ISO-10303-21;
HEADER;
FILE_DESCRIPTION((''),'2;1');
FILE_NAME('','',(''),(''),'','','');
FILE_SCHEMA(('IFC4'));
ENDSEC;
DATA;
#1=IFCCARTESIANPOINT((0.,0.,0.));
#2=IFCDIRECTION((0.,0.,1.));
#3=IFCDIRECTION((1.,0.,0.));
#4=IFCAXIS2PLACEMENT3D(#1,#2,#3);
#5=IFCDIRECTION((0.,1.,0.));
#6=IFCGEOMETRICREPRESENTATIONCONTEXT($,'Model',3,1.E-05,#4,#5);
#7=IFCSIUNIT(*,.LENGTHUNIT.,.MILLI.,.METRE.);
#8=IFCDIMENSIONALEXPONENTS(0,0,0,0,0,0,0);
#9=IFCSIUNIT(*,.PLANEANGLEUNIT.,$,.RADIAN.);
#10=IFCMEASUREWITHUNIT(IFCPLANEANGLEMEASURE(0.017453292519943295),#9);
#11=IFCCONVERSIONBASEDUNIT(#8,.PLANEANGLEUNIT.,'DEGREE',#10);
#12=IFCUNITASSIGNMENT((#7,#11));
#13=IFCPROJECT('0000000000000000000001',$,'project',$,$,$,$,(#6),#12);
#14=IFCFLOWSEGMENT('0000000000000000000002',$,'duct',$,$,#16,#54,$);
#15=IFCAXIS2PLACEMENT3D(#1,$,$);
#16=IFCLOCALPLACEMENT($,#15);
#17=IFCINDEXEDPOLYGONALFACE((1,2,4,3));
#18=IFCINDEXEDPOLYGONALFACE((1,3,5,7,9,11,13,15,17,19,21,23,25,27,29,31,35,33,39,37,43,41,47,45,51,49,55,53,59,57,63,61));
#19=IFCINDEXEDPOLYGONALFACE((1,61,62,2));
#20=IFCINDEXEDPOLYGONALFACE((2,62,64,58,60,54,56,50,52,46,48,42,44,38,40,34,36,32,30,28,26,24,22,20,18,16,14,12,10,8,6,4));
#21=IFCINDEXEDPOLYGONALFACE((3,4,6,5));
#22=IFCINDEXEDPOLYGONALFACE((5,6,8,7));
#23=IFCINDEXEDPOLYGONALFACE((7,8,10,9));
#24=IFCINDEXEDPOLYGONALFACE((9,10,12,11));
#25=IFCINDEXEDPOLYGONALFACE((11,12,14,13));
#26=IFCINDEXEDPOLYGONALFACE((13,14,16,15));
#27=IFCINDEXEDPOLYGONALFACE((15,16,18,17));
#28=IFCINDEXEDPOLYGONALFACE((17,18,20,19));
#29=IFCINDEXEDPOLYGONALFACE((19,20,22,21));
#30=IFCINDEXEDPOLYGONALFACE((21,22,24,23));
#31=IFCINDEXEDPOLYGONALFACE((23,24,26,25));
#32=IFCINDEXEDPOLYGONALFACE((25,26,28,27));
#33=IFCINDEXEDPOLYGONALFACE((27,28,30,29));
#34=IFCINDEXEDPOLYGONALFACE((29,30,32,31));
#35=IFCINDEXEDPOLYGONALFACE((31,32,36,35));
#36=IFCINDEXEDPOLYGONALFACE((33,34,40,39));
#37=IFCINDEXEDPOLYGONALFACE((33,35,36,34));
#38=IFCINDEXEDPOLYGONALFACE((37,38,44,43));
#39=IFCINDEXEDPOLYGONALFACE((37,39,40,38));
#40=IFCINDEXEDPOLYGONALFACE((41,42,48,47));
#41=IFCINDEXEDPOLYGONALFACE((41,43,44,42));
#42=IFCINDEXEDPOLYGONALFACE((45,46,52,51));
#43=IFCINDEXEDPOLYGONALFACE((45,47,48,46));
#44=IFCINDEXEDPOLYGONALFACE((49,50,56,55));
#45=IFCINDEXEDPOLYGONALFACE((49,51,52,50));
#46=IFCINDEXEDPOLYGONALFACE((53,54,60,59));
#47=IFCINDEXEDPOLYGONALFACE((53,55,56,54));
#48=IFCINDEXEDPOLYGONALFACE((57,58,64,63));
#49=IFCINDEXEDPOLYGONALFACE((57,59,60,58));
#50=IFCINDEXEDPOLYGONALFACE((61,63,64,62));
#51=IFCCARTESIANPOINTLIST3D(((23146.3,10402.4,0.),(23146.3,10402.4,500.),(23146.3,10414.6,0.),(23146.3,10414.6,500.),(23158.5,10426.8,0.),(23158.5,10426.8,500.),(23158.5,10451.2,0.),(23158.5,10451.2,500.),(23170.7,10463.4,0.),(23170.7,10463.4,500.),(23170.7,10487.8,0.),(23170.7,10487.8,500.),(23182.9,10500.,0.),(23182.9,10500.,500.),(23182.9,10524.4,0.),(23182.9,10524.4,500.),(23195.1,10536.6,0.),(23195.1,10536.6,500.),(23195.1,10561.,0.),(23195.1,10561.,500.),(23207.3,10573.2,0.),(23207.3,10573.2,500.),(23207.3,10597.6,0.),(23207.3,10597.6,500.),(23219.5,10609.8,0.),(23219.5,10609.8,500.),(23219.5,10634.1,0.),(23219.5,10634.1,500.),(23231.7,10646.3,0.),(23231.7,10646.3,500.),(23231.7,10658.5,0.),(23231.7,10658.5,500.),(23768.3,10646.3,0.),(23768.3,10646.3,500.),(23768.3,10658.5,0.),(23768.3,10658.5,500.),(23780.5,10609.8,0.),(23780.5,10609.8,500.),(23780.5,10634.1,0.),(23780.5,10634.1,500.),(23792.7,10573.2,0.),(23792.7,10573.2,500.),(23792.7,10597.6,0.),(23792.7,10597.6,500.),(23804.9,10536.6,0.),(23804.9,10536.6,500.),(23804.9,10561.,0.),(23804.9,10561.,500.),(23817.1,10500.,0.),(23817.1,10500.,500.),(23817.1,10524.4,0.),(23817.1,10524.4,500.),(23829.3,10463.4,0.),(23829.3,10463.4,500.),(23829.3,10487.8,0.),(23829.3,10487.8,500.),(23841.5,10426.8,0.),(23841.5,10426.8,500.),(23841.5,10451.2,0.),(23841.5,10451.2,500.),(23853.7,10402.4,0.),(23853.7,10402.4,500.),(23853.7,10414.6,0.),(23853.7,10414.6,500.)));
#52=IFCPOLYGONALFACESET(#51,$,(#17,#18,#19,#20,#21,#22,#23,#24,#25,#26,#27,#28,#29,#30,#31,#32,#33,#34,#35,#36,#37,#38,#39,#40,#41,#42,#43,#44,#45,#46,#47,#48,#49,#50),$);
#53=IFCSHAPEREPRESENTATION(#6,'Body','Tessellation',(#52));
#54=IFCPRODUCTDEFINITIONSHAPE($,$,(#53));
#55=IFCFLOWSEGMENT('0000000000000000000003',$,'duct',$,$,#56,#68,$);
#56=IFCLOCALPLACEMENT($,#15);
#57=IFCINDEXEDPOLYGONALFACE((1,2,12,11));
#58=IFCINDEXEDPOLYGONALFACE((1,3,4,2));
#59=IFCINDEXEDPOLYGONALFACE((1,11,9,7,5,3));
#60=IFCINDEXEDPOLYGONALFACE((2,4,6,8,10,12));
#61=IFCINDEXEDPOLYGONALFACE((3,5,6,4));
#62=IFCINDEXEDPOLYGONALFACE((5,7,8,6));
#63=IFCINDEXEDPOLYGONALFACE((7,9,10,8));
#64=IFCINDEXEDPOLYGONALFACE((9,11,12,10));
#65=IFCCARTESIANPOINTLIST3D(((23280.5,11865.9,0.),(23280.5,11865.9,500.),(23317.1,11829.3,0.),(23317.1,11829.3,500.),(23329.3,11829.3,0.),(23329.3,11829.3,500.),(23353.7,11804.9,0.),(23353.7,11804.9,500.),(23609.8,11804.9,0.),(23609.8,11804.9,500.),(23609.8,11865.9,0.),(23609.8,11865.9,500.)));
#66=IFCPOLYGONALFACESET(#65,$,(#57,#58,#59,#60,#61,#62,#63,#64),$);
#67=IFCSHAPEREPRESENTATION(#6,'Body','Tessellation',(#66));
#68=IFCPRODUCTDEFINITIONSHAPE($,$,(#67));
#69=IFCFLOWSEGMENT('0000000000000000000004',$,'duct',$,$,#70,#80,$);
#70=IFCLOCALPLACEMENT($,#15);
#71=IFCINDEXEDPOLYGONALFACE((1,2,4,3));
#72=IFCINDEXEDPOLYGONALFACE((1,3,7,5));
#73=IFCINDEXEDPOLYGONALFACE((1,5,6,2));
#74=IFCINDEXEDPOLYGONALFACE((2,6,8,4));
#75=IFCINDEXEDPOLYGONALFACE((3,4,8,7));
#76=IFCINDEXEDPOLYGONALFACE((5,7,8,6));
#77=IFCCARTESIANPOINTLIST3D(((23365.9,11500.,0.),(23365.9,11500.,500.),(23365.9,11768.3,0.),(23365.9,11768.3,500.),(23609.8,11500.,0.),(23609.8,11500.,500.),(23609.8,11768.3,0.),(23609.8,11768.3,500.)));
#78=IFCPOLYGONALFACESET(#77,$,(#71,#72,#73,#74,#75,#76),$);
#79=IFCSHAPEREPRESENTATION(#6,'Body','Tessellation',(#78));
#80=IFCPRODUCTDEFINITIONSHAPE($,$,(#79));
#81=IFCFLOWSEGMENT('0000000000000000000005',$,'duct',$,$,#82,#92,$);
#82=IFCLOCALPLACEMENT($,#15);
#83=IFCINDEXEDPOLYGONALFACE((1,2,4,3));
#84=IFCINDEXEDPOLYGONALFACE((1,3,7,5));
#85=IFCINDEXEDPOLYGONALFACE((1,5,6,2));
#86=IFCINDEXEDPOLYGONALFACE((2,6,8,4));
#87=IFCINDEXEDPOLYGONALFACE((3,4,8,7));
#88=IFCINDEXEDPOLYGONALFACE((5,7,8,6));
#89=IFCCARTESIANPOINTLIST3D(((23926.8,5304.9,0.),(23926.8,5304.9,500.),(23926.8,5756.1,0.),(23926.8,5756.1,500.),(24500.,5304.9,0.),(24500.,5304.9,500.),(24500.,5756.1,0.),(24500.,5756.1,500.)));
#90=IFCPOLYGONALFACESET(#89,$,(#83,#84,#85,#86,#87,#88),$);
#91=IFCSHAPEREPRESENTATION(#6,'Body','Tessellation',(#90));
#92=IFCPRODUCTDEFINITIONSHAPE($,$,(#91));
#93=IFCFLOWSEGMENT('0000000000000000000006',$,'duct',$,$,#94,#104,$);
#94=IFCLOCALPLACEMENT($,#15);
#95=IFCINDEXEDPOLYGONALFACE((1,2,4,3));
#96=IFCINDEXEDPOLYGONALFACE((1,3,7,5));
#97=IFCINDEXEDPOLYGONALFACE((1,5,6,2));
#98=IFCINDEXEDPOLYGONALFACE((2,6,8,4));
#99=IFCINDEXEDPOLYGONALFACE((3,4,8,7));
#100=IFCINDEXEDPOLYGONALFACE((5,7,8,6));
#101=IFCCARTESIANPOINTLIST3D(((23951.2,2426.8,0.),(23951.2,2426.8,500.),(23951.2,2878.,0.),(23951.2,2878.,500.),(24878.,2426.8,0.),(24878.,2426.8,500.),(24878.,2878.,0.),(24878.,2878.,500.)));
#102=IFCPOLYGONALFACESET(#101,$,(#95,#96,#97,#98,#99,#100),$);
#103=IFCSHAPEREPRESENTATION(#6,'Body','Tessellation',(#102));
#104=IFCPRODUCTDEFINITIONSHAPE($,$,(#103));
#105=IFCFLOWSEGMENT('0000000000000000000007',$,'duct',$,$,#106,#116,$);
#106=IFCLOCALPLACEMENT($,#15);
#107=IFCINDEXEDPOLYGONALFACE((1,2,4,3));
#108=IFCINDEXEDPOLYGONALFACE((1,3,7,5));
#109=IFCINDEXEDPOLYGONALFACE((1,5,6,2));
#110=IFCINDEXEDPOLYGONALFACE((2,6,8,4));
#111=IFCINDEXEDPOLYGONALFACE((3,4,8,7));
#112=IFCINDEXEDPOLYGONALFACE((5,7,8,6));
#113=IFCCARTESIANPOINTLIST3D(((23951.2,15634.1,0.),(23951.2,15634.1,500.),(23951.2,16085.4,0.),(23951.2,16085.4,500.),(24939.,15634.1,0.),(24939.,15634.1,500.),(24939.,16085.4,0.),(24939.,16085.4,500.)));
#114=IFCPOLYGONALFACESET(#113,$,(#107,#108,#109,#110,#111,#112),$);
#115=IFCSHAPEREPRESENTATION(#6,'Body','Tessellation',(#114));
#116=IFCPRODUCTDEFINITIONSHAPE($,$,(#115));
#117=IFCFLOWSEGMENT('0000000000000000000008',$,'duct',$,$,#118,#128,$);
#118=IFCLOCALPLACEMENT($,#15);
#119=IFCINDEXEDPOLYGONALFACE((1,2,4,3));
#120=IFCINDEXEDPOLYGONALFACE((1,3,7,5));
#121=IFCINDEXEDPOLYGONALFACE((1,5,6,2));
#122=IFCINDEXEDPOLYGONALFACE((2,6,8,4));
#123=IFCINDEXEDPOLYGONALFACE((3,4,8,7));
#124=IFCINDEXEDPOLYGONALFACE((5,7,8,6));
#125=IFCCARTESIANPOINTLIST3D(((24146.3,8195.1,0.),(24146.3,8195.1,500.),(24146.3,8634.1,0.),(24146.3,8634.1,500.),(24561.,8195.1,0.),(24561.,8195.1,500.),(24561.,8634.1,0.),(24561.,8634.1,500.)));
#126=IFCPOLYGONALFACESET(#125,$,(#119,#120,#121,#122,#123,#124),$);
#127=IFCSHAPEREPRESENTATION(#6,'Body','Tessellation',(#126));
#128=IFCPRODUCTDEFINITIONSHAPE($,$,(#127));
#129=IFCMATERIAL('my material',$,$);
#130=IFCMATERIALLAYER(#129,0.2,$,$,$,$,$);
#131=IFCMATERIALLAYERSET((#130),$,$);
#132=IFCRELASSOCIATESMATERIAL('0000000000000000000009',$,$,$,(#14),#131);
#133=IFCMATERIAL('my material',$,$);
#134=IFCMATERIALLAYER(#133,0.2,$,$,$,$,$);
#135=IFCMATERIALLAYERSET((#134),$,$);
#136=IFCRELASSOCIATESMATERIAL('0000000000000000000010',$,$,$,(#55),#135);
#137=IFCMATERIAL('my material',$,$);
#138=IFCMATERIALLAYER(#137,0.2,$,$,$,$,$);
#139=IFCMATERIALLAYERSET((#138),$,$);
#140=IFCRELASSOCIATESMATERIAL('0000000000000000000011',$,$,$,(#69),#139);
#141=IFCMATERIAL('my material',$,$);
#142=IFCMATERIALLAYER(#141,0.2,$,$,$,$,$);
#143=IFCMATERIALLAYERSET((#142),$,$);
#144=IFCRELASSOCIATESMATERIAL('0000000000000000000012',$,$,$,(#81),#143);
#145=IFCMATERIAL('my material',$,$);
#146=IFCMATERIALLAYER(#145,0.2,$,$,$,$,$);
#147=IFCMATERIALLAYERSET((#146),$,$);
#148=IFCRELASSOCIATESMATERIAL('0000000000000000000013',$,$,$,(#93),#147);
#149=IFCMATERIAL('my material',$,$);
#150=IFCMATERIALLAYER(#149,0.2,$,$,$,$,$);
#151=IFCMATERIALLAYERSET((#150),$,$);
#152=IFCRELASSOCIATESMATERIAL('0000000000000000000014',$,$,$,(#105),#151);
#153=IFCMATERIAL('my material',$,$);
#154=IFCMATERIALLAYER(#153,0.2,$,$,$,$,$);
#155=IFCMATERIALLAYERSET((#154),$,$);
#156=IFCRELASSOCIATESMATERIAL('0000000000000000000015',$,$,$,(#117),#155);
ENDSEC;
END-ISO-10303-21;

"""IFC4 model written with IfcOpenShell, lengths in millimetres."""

from ifc_helpers import new_model, entity, si_unit, converted_unit, direction, origin_with_axes, place, context, project, polyline, outline, extrude, material, layer, layer_set, layer_usage, element, save


model = new_model("IFC4")

# Units and contexts
model_context = context("Model", 3, precision=1e-05, world=origin_with_axes(), true_north=direction((0.0, 1.0, 0.0)))
ifc_project = project(units=[si_unit("LENGTHUNIT", "METRE", prefix="MILLI"), converted_unit("PLANEANGLEUNIT", "DEGREE", entity("IfcPlaneAngleMeasure", 0.017453292519943295), si_unit("PLANEANGLEUNIT", "RADIAN"), dimensions=[0, 0, 0, 0, 0, 0, 0])], contexts=[model_context])

# Flow segments
ifc_material_1 = material(Name="my material")
ifc_layer_1 = layer(ifc_material_1, 0.2)
ifc_layer_set_1 = layer_set([ifc_layer_1])
ifc_layer_usage_1 = layer_usage(ifc_layer_set_1, "AXIS2", "POSITIVE", -0.1)
flow_segment_1_placement = place(None, origin_with_axes())
element("IfcFlowSegment", 1, at=flow_segment_1_placement, material=ifc_layer_usage_1, Name="duct", context=model_context, shape_type="SweptSolid", body=[
    extrude(outline(polyline([(23146.3, 10402.4), (23853.7, 10402.4), (23853.7, 10414.6), (23841.5, 10426.8), (23841.5, 10451.2), (23829.3, 10463.4), (23829.3, 10487.8), (23817.1, 10500.0), (23817.1, 10524.4), (23804.9, 10536.6), (23804.9, 10561.0), (23792.7, 10573.2), (23792.7, 10597.6), (23780.5, 10609.8), (23780.5, 10634.1), (23768.3, 10646.3), (23768.3, 10658.5), (23231.7, 10658.5), (23231.7, 10646.3), (23219.5, 10634.1), (23219.5, 10609.8), (23207.3, 10597.6), (23207.3, 10573.2), (23195.1, 10561.0), (23195.1, 10536.6), (23182.9, 10524.4), (23182.9, 10500.0), (23170.7, 10487.8), (23170.7, 10463.4), (23158.5, 10451.2), (23158.5, 10426.8), (23146.3, 10414.6), (23146.3, 10402.4)])), origin_with_axes(), (0.0, 0.0, 1.0), 500.0),
])
ifc_material_2 = material(Name="my material")
ifc_layer_2 = layer(ifc_material_2, 0.2)
ifc_layer_set_2 = layer_set([ifc_layer_2])
ifc_layer_usage_2 = layer_usage(ifc_layer_set_2, "AXIS2", "POSITIVE", -0.1)
flow_segment_2_placement = place(None, origin_with_axes())
element("IfcFlowSegment", 2, at=flow_segment_2_placement, material=ifc_layer_usage_2, Name="duct", context=model_context, shape_type="SweptSolid", body=[
    extrude(outline(polyline([(23268.3, 11865.9), (23280.5, 11865.9), (23317.1, 11829.3), (23329.3, 11829.3), (23353.7, 11804.9), (23609.8, 11804.9), (23609.8, 11865.9), (23268.3, 11865.9)])), origin_with_axes(), (0.0, 0.0, 1.0), 500.0),
])
ifc_material_3 = material(Name="my material")
ifc_layer_3 = layer(ifc_material_3, 0.2)
ifc_layer_set_3 = layer_set([ifc_layer_3])
ifc_layer_usage_3 = layer_usage(ifc_layer_set_3, "AXIS2", "POSITIVE", -0.1)
flow_segment_3_placement = place(None, origin_with_axes())
element("IfcFlowSegment", 3, at=flow_segment_3_placement, material=ifc_layer_usage_3, Name="duct", context=model_context, shape_type="SweptSolid", body=[
    extrude(outline(polyline([(23365.9, 11500.0), (23609.8, 11500.0), (23609.8, 11768.3), (23365.9, 11768.3), (23365.9, 11500.0)])), origin_with_axes(), (0.0, 0.0, 1.0), 500.0),
])
ifc_material_4 = material(Name="my material")
ifc_layer_4 = layer(ifc_material_4, 0.2)
ifc_layer_set_4 = layer_set([ifc_layer_4])
ifc_layer_usage_4 = layer_usage(ifc_layer_set_4, "AXIS2", "POSITIVE", -0.1)
flow_segment_4_placement = place(None, origin_with_axes())
element("IfcFlowSegment", 4, at=flow_segment_4_placement, material=ifc_layer_usage_4, Name="duct", context=model_context, shape_type="SweptSolid", body=[
    extrude(outline(polyline([(23926.8, 5304.9), (24500.0, 5304.9), (24500.0, 5756.1), (23926.8, 5756.1), (23926.8, 5304.9)])), origin_with_axes(), (0.0, 0.0, 1.0), 500.0),
])
ifc_material_5 = material(Name="my material")
ifc_layer_5 = layer(ifc_material_5, 0.2)
ifc_layer_set_5 = layer_set([ifc_layer_5])
ifc_layer_usage_5 = layer_usage(ifc_layer_set_5, "AXIS2", "POSITIVE", -0.1)
flow_segment_5_placement = place(None, origin_with_axes())
element("IfcFlowSegment", 5, at=flow_segment_5_placement, material=ifc_layer_usage_5, Name="duct", context=model_context, shape_type="SweptSolid", body=[
    extrude(outline(polyline([(23951.2, 2426.8), (24878.0, 2426.8), (24878.0, 2878.0), (23951.2, 2878.0), (23951.2, 2426.8)])), origin_with_axes(), (0.0, 0.0, 1.0), 500.0),
])
ifc_material_6 = material(Name="my material")
ifc_layer_6 = layer(ifc_material_6, 0.2)
ifc_layer_set_6 = layer_set([ifc_layer_6])
ifc_layer_usage_6 = layer_usage(ifc_layer_set_6, "AXIS2", "POSITIVE", -0.1)
flow_segment_6_placement = place(None, origin_with_axes())
element("IfcFlowSegment", 6, at=flow_segment_6_placement, material=ifc_layer_usage_6, Name="duct", context=model_context, shape_type="SweptSolid", body=[
    extrude(outline(polyline([(23951.2, 15634.1), (24939.0, 15634.1), (24939.0, 16085.4), (23951.2, 16085.4), (23951.2, 15634.1)])), origin_with_axes(), (0.0, 0.0, 1.0), 500.0),
])
ifc_material_7 = material(Name="my material")
ifc_layer_7 = layer(ifc_material_7, 0.2)
ifc_layer_set_7 = layer_set([ifc_layer_7])
ifc_layer_usage_7 = layer_usage(ifc_layer_set_7, "AXIS2", "POSITIVE", -0.1)
flow_segment_7_placement = place(None, origin_with_axes())
element("IfcFlowSegment", 7, at=flow_segment_7_placement, material=ifc_layer_usage_7, Name="duct", context=model_context, shape_type="SweptSolid", body=[
    extrude(outline(polyline([(24146.3, 8195.1), (24561.0, 8195.1), (24561.0, 8634.1), (24146.3, 8634.1), (24146.3, 8195.1)])), origin_with_axes(), (0.0, 0.0, 1.0), 500.0),
])

save(model, "model.ifc")
